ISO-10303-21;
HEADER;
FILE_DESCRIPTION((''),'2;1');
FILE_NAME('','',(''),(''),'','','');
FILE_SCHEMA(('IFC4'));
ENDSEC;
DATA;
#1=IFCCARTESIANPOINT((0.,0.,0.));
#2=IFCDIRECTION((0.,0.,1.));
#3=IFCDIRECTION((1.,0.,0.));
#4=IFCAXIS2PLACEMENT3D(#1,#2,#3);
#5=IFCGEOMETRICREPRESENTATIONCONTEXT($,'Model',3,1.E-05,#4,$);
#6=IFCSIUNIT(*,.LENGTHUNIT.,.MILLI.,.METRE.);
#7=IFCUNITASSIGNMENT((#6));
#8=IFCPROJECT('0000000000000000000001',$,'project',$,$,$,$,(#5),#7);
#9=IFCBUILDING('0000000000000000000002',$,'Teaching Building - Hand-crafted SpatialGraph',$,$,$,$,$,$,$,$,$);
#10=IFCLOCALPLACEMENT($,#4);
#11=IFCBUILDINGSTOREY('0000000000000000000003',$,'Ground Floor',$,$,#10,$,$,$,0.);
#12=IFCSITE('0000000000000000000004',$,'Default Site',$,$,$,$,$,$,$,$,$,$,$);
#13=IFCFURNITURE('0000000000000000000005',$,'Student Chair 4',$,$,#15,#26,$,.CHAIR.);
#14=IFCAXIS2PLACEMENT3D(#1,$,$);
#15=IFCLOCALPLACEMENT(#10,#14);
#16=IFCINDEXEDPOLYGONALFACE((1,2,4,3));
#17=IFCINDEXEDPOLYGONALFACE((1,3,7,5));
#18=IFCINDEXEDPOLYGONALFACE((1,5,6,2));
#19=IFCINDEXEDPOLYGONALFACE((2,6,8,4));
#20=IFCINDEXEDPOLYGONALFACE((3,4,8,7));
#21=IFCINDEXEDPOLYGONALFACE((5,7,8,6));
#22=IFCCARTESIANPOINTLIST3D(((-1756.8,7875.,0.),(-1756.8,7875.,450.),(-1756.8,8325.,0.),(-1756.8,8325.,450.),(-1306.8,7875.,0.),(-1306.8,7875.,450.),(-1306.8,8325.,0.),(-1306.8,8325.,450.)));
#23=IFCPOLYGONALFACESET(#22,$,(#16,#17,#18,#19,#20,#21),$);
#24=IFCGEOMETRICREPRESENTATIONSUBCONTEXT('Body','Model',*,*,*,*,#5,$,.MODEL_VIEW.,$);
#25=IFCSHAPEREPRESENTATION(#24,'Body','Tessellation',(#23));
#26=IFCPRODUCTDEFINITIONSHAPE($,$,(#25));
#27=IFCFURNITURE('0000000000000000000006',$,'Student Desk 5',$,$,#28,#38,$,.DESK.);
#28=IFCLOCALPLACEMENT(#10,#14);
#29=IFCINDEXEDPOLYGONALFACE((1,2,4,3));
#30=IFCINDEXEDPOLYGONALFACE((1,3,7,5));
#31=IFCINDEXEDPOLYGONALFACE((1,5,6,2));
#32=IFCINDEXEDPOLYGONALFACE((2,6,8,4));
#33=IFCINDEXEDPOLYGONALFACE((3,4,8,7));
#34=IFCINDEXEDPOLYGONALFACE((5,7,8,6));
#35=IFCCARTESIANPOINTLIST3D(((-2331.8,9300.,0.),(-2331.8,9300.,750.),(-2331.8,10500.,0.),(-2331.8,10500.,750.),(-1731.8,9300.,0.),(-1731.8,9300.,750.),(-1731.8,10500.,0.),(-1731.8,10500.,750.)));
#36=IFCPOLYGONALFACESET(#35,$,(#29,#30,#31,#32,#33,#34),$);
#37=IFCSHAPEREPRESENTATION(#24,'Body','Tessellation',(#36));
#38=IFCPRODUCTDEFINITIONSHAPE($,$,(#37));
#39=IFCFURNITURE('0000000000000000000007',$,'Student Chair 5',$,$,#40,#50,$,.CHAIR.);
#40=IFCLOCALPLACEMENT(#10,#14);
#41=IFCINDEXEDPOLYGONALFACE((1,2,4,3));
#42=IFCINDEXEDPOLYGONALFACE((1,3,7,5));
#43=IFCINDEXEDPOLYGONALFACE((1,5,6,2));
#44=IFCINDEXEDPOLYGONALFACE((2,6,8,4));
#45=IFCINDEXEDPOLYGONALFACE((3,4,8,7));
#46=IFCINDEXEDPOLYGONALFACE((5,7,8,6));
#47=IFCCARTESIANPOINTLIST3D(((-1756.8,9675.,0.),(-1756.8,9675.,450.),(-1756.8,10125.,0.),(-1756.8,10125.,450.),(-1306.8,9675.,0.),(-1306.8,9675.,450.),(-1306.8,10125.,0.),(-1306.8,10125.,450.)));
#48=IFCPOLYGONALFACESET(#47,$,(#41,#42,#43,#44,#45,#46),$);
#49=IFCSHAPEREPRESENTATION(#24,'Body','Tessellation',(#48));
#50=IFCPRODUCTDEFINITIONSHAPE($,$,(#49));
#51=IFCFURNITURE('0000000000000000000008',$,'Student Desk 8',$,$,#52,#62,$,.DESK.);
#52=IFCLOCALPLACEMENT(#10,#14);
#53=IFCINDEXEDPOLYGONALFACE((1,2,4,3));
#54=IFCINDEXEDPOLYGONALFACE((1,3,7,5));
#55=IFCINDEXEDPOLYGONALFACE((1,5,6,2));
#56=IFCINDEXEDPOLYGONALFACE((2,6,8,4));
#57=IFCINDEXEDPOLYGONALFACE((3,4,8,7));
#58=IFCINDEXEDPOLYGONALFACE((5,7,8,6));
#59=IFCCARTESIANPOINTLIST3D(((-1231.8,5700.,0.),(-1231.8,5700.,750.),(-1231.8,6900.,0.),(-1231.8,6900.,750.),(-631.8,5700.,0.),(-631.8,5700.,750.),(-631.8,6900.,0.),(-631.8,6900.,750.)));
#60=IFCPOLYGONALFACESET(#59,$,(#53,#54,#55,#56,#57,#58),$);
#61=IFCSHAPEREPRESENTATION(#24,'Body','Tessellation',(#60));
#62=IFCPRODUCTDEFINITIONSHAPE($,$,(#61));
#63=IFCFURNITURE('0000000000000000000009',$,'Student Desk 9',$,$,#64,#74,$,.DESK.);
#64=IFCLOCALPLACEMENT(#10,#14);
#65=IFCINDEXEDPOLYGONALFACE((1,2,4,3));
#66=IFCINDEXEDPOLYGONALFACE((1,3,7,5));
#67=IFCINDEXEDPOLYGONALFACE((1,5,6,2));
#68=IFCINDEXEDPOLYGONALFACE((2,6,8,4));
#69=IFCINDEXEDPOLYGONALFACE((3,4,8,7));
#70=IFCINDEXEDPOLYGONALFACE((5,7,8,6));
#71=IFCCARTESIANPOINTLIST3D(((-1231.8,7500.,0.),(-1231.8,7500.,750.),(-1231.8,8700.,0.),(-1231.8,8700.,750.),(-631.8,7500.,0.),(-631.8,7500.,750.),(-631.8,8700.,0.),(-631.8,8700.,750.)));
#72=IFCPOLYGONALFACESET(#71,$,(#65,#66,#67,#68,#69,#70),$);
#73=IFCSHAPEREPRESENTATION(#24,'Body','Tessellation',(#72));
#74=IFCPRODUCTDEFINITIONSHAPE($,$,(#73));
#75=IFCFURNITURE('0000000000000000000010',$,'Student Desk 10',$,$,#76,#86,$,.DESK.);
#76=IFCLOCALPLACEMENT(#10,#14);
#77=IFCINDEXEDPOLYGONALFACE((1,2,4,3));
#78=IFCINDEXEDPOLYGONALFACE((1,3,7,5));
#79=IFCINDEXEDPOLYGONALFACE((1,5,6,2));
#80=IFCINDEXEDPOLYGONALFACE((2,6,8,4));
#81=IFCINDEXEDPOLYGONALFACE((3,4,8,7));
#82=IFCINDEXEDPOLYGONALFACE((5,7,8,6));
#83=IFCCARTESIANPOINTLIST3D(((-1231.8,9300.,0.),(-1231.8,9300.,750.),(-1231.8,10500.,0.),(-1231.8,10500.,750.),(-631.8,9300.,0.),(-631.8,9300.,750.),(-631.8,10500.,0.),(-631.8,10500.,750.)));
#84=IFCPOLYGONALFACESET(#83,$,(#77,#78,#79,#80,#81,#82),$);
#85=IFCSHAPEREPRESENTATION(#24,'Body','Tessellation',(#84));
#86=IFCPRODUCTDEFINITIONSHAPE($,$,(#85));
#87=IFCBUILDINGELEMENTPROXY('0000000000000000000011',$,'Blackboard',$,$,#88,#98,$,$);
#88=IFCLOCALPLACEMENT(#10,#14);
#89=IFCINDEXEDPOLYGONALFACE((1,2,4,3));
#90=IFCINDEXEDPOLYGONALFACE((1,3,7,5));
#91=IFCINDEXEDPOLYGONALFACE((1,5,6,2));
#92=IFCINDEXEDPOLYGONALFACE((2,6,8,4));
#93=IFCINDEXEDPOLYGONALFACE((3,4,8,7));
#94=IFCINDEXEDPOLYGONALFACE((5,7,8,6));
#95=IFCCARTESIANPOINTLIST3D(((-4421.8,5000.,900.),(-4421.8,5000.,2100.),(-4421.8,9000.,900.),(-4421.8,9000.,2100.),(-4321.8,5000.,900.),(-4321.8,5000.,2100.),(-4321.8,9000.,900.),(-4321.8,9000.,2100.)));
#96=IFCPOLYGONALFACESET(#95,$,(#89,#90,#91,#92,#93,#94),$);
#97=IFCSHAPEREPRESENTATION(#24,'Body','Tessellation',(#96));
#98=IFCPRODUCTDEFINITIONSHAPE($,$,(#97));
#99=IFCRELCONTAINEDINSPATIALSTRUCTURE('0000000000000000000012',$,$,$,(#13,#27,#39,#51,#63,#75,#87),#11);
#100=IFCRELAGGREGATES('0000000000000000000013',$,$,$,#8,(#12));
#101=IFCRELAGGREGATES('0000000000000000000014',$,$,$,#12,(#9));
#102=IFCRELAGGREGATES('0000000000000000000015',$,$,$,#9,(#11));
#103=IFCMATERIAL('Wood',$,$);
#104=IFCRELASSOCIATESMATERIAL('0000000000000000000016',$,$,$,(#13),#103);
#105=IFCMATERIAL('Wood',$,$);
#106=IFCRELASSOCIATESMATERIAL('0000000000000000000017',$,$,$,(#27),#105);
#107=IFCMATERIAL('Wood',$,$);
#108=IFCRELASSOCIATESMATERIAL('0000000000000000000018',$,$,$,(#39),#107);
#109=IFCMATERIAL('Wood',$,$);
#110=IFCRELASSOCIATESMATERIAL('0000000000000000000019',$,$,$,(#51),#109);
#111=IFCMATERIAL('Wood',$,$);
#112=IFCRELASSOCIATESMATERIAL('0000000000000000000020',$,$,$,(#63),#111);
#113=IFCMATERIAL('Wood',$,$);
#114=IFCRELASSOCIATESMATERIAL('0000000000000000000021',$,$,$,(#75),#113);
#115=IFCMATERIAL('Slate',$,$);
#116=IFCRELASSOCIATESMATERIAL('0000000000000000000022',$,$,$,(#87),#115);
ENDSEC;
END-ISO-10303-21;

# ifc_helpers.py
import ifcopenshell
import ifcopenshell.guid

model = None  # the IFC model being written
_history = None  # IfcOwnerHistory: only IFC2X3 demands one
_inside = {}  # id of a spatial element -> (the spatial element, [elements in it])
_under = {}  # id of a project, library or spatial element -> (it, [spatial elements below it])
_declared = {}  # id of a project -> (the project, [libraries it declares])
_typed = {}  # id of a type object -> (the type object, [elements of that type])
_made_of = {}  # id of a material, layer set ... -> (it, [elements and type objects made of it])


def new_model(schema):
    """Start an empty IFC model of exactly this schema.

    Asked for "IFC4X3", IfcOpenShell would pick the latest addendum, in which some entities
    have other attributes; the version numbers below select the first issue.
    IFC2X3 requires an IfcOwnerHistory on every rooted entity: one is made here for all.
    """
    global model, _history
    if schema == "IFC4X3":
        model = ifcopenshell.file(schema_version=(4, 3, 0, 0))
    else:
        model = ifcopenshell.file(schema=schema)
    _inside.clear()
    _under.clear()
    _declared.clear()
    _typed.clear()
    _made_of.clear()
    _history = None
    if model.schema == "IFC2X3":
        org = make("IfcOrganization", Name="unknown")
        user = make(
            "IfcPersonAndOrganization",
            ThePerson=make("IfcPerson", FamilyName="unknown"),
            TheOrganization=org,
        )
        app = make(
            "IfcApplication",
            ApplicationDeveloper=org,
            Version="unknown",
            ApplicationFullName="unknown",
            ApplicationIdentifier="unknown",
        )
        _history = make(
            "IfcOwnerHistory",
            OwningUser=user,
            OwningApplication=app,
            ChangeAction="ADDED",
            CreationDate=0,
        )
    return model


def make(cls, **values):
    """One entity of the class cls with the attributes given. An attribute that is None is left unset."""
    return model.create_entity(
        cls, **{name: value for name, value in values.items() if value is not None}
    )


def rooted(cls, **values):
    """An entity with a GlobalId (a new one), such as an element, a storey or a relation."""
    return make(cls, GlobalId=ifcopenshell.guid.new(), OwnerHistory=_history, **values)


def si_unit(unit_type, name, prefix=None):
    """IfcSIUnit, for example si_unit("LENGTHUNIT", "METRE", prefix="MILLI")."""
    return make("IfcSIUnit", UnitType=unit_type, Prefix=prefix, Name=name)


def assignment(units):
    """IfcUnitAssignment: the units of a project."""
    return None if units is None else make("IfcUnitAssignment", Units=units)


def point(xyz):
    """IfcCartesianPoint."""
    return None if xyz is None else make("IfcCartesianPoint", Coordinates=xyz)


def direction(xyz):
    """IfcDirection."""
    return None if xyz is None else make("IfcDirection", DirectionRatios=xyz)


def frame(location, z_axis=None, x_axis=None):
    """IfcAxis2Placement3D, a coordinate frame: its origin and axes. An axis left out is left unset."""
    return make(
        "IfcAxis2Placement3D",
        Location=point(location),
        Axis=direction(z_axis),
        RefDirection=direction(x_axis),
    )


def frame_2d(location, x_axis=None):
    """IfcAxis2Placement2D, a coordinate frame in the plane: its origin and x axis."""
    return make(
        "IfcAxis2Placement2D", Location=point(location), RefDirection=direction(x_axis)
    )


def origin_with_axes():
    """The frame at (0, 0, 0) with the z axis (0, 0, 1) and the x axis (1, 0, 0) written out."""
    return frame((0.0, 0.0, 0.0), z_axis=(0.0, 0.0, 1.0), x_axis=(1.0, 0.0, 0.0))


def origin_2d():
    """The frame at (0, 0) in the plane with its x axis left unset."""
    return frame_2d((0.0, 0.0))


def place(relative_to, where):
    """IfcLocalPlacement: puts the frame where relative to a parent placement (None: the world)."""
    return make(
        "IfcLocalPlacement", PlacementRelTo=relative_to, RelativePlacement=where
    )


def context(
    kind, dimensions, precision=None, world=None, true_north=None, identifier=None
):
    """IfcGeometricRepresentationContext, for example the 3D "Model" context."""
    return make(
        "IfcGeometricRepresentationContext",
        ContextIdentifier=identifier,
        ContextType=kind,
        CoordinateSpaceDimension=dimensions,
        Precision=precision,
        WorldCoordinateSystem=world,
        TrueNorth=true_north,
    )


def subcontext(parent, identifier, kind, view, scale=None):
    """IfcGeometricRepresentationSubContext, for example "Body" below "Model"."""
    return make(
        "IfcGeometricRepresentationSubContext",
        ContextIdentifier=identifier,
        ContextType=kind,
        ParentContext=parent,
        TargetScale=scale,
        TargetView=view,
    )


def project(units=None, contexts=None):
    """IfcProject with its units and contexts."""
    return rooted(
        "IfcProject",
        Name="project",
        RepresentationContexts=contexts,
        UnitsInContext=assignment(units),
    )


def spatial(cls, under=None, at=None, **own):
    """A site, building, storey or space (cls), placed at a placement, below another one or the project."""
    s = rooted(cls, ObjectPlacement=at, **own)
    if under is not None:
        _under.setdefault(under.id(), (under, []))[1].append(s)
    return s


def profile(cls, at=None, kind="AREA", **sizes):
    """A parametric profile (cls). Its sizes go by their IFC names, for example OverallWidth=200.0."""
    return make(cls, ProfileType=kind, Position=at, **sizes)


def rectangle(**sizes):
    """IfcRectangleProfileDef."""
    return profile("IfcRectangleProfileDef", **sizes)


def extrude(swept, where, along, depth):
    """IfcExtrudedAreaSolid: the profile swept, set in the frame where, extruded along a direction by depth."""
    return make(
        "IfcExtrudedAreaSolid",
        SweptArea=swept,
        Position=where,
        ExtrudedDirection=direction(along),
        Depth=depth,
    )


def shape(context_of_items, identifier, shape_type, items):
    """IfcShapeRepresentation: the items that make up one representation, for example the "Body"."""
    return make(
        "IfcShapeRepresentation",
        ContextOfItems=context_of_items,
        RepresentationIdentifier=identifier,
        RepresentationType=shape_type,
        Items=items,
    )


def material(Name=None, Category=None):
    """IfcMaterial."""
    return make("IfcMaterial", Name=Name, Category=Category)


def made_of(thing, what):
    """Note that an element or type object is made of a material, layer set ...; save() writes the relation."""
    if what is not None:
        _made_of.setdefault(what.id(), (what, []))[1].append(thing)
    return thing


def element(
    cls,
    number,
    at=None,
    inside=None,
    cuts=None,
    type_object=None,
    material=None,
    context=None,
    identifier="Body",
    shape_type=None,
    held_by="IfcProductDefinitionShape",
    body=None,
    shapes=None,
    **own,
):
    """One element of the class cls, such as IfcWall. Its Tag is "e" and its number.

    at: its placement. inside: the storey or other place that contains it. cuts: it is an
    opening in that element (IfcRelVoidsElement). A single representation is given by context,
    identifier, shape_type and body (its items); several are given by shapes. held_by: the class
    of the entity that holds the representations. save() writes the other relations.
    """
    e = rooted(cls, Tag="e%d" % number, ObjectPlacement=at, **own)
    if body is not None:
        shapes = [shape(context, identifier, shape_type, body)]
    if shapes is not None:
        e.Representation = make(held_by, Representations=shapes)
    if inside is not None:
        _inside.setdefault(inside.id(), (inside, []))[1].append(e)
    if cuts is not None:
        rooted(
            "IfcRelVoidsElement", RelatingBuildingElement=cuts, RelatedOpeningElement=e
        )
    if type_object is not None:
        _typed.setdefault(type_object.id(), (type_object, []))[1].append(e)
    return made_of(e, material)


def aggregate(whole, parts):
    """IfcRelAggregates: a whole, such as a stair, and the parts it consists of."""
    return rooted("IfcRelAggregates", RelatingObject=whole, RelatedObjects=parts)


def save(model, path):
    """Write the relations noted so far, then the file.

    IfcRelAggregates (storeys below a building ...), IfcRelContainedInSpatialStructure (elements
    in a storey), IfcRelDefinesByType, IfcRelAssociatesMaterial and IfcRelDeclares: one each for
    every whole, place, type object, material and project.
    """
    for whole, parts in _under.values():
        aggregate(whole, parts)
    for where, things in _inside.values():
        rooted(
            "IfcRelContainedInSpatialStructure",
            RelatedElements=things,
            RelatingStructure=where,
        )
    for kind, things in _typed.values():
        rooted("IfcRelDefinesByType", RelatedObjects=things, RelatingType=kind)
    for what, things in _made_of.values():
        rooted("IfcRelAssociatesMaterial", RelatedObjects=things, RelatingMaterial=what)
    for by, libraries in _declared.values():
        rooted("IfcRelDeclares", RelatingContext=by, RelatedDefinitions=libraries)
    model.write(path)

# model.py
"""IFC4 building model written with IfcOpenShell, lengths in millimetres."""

from ifc_helpers import new_model, si_unit, frame, origin_with_axes, origin_2d, place, context, subcontext, project, spatial, rectangle, extrude, material, element, save


model = new_model("IFC4")

# Units and contexts
model_context = context("Model", 3, precision=1e-05, world=origin_with_axes())
body_context = subcontext(model_context, "Body", "Model", "MODEL_VIEW")
ifc_project = project(units=[si_unit("LENGTHUNIT", "METRE", prefix="MILLI")], contexts=[model_context])

# Site, building, storey
site = spatial("IfcSite", under=ifc_project, Name="Default Site")
building = spatial("IfcBuilding", under=site, Name="Teaching Building - Hand-crafted SpatialGraph")
storey_placement = place(None, origin_with_axes())
storey = spatial("IfcBuildingStorey", under=building, at=storey_placement, Name="Ground Floor", Elevation=0.0)

# Furniture
ifc_material_1 = material(Name="Wood")
furniture_1_placement = place(storey_placement, frame((-1531.8, 8100.0, 0.0), z_axis=(0.0, 0.0, 1.0), x_axis=(1.0, 0.0, 0.0)))
element("IfcFurniture", 1, at=furniture_1_placement, inside=storey, material=ifc_material_1, Name="Student Chair 4", PredefinedType="CHAIR", context=body_context, shape_type="SweptSolid", body=[
    extrude(rectangle(XDim=450.0, YDim=450.0, at=origin_2d()), origin_with_axes(), (0.0, 0.0, 1.0), 450.0),
])
ifc_material_2 = material(Name="Wood")
furniture_2_placement = place(storey_placement, frame((-2031.8, 9900.0, 0.0), z_axis=(0.0, 0.0, 1.0), x_axis=(0.0, 1.0, 0.0)))
element("IfcFurniture", 2, at=furniture_2_placement, inside=storey, material=ifc_material_2, Name="Student Desk 5", PredefinedType="DESK", context=body_context, shape_type="SweptSolid", body=[
    extrude(rectangle(XDim=1200.0, YDim=600.0, at=origin_2d()), origin_with_axes(), (0.0, 0.0, 1.0), 750.0),
])
ifc_material_3 = material(Name="Wood")
furniture_3_placement = place(storey_placement, frame((-1531.8, 9900.0, 0.0), z_axis=(0.0, 0.0, 1.0), x_axis=(1.0, 0.0, 0.0)))
element("IfcFurniture", 3, at=furniture_3_placement, inside=storey, material=ifc_material_3, Name="Student Chair 5", PredefinedType="CHAIR", context=body_context, shape_type="SweptSolid", body=[
    extrude(rectangle(XDim=450.0, YDim=450.0, at=origin_2d()), origin_with_axes(), (0.0, 0.0, 1.0), 450.0),
])
ifc_material_4 = material(Name="Wood")
furniture_4_placement = place(storey_placement, frame((-931.8, 6300.0, 0.0), z_axis=(0.0, 0.0, 1.0), x_axis=(0.0, 1.0, 0.0)))
element("IfcFurniture", 4, at=furniture_4_placement, inside=storey, material=ifc_material_4, Name="Student Desk 8", PredefinedType="DESK", context=body_context, shape_type="SweptSolid", body=[
    extrude(rectangle(XDim=1200.0, YDim=600.0, at=origin_2d()), origin_with_axes(), (0.0, 0.0, 1.0), 750.0),
])
ifc_material_5 = material(Name="Wood")
furniture_5_placement = place(storey_placement, frame((-931.8, 8100.0, 0.0), z_axis=(0.0, 0.0, 1.0), x_axis=(0.0, 1.0, 0.0)))
element("IfcFurniture", 5, at=furniture_5_placement, inside=storey, material=ifc_material_5, Name="Student Desk 9", PredefinedType="DESK", context=body_context, shape_type="SweptSolid", body=[
    extrude(rectangle(XDim=1200.0, YDim=600.0, at=origin_2d()), origin_with_axes(), (0.0, 0.0, 1.0), 750.0),
])
ifc_material_6 = material(Name="Wood")
furniture_6_placement = place(storey_placement, frame((-931.8, 9900.0, 0.0), z_axis=(0.0, 0.0, 1.0), x_axis=(0.0, 1.0, 0.0)))
element("IfcFurniture", 6, at=furniture_6_placement, inside=storey, material=ifc_material_6, Name="Student Desk 10", PredefinedType="DESK", context=body_context, shape_type="SweptSolid", body=[
    extrude(rectangle(XDim=1200.0, YDim=600.0, at=origin_2d()), origin_with_axes(), (0.0, 0.0, 1.0), 750.0),
])

# Building element proxy
ifc_material_7 = material(Name="Slate")
proxy_placement = place(storey_placement, frame((-4371.8, 7000.0, 900.0), z_axis=(0.0, 0.0, 1.0), x_axis=(1.0, 0.0, 0.0)))
element("IfcBuildingElementProxy", 7, at=proxy_placement, inside=storey, material=ifc_material_7, Name="Blackboard", context=body_context, shape_type="SweptSolid", body=[
    extrude(rectangle(XDim=100.0, YDim=4000.0, at=origin_2d()), origin_with_axes(), (0.0, 0.0, 1.0), 1200.0),
])

save(model, "model.ifc")
